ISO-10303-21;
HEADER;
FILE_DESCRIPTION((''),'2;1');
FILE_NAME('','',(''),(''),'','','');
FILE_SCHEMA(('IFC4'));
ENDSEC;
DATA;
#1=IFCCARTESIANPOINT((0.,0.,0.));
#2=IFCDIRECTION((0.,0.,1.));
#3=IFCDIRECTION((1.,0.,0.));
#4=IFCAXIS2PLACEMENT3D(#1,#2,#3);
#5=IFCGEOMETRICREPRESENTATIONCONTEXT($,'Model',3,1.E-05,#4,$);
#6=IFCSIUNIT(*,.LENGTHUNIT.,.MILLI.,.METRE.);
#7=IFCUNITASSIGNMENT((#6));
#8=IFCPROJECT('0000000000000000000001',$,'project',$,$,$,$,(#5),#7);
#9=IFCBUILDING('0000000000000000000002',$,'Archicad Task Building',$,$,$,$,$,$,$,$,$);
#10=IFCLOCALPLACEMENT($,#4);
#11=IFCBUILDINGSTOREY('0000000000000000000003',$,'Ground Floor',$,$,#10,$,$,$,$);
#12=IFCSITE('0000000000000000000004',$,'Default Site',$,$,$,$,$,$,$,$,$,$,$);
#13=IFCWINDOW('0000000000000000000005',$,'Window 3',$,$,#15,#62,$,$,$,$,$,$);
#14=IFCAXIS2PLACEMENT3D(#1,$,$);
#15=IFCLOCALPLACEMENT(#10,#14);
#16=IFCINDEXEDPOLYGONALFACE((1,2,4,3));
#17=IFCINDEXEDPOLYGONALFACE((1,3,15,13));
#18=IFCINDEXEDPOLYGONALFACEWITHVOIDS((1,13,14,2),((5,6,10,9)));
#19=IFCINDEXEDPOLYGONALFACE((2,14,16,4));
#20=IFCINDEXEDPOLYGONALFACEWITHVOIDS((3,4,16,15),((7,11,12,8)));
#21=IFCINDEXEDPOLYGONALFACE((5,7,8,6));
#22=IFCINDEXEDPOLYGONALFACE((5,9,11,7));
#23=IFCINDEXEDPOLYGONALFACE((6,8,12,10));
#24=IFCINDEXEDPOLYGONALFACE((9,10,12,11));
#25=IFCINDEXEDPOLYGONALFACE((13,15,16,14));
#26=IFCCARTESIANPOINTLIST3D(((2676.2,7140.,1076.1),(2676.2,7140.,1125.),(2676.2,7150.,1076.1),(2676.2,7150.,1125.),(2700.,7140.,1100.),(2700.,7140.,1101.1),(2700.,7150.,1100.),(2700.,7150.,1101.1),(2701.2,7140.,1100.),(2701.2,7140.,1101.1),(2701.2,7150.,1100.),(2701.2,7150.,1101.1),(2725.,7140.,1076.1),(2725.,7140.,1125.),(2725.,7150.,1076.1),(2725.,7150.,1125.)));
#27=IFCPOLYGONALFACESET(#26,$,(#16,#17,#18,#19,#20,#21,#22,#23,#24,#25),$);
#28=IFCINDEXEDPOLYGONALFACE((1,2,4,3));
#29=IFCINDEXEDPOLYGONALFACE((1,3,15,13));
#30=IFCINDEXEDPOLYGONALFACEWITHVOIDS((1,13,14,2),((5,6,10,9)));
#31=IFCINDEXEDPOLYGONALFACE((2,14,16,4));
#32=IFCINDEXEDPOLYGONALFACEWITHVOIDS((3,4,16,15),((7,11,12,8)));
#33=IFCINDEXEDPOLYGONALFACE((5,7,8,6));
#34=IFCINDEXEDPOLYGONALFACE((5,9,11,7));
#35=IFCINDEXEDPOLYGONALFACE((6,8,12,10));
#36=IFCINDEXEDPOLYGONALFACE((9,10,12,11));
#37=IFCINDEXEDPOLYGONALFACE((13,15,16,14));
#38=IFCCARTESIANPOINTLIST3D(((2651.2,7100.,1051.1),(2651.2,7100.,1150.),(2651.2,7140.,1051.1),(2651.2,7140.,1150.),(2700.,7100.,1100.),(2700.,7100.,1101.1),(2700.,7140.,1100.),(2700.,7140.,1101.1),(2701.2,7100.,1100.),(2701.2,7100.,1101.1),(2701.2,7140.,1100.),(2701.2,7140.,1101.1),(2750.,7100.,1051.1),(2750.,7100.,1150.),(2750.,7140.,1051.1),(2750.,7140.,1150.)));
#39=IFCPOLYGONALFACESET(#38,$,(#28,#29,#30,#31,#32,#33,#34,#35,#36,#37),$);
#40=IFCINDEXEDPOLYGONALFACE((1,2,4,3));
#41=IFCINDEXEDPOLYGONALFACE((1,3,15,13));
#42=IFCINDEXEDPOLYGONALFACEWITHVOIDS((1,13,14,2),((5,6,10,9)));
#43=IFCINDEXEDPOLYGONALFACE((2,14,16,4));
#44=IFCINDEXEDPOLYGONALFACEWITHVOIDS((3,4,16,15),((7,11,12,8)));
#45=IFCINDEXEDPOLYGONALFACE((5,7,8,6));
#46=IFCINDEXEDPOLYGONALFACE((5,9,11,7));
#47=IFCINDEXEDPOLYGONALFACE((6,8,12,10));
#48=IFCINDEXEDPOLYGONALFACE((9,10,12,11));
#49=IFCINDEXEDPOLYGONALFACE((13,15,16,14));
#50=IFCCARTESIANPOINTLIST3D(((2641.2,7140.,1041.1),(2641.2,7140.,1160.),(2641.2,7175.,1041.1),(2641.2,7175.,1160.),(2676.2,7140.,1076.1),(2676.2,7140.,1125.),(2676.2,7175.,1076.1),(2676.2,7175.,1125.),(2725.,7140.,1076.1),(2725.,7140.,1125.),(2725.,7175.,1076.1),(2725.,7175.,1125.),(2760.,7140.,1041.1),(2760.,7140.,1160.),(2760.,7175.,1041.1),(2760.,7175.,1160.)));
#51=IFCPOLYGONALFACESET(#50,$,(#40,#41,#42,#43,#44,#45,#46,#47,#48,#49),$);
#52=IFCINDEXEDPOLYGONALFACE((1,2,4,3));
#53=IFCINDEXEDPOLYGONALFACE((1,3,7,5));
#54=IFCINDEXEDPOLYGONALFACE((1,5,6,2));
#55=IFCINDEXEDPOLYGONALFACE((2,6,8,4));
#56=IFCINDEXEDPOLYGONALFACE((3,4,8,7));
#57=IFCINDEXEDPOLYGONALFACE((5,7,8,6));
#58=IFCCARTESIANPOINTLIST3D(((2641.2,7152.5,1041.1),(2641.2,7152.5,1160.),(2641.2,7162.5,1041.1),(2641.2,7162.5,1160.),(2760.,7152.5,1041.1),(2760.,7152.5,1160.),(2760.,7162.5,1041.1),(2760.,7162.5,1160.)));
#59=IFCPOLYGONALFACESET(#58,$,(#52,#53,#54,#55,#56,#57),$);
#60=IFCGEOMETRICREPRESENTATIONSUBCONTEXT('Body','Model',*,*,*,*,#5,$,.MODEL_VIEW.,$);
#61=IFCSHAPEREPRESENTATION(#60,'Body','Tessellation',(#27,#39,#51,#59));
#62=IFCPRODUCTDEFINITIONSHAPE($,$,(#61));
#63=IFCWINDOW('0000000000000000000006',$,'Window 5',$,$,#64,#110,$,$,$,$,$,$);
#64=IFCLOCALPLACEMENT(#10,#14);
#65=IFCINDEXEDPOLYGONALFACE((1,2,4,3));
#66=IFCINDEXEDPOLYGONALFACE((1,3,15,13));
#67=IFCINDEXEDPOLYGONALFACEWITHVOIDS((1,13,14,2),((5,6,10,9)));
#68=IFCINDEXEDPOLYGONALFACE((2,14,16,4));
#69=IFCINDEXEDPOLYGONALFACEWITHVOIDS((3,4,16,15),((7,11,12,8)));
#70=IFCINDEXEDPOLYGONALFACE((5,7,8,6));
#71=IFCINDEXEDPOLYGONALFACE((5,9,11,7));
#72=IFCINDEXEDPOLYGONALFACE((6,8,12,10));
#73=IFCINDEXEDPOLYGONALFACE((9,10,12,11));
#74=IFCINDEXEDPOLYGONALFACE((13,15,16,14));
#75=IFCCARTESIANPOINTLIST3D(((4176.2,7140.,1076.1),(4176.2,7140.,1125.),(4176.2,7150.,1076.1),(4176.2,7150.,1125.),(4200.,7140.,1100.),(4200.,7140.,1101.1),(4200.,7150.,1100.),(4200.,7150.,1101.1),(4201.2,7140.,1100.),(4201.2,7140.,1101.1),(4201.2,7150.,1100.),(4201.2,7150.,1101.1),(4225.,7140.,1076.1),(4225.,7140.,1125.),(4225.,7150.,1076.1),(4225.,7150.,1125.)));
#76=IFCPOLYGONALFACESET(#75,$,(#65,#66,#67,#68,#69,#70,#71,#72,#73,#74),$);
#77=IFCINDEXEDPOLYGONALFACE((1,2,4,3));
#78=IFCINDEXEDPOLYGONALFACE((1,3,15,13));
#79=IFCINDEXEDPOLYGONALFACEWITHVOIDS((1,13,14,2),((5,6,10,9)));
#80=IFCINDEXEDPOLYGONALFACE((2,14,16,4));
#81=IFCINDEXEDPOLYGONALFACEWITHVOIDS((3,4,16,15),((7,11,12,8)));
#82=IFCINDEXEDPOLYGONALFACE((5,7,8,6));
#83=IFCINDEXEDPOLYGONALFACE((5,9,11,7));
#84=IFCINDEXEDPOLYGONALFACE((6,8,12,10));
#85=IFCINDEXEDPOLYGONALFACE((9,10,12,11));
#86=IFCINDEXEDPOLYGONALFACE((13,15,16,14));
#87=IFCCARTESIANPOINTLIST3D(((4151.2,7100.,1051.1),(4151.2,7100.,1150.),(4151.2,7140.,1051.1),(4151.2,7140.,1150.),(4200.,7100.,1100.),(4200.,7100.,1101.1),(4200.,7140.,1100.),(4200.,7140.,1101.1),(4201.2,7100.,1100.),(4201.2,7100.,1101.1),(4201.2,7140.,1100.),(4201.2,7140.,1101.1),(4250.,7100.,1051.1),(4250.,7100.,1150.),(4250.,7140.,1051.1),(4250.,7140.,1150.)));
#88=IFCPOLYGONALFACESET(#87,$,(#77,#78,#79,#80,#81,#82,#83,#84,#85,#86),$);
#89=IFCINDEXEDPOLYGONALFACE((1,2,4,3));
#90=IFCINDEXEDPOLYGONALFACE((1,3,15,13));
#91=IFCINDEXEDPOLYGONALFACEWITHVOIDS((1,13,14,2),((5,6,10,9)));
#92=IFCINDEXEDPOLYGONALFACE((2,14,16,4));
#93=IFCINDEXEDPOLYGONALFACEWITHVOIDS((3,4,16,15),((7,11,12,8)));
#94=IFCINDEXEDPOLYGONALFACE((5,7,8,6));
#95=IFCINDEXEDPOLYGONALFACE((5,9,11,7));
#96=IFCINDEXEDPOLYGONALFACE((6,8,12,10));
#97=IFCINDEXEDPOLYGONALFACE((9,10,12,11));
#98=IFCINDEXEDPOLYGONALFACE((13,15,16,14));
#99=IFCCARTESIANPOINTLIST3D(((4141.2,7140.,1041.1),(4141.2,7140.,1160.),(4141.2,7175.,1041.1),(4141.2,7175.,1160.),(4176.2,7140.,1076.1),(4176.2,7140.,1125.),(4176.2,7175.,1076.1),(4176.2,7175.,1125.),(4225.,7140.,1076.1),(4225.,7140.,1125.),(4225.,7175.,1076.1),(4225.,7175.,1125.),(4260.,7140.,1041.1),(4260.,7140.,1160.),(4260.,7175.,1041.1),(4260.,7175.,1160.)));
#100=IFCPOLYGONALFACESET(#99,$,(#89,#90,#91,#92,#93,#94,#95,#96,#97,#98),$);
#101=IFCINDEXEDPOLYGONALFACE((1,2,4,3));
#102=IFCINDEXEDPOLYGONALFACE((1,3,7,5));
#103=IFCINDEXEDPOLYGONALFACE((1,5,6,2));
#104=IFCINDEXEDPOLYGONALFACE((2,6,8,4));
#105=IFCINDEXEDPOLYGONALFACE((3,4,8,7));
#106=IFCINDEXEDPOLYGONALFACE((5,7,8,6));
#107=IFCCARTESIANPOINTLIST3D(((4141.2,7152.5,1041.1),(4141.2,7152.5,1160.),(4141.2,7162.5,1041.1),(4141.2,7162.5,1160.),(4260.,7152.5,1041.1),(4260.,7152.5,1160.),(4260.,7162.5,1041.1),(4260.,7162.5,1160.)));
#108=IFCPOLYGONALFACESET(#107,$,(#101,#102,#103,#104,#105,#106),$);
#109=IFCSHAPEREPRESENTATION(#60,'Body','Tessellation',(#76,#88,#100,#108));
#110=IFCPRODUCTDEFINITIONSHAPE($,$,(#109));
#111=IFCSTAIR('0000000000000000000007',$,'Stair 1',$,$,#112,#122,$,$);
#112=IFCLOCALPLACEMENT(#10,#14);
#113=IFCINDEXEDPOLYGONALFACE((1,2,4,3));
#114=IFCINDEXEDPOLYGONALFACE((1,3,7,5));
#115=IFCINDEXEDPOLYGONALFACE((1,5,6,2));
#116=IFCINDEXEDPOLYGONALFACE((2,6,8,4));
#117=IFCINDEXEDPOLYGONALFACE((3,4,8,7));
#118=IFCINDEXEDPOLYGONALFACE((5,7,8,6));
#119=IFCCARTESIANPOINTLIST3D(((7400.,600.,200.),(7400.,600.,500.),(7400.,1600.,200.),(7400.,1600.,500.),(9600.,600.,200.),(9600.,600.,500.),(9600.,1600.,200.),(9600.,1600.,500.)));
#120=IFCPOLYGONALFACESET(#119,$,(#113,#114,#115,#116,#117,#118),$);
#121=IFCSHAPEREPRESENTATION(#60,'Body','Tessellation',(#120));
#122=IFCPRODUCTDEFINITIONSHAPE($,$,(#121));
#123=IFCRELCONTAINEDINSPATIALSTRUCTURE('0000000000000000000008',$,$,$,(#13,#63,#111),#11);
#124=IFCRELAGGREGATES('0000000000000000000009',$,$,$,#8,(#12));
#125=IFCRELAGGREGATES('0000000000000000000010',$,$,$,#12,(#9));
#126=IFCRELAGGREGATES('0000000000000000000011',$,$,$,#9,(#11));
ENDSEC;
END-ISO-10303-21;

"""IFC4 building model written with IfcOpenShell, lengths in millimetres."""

from ifc_helpers import new_model, si_unit, frame, origin_with_axes, place, context, subcontext, project, spatial, line, indexed_curve, outline, extrude, element, save


model = new_model("IFC4")

# Units and contexts
model_context = context("Model", 3, precision=1e-05, world=origin_with_axes())
body_context = subcontext(model_context, "Body", "Model", "MODEL_VIEW")
ifc_project = project(units=[si_unit("LENGTHUNIT", "METRE", prefix="MILLI")], contexts=[model_context])

# Site, building, storey
site = spatial("IfcSite", under=ifc_project, Name="Default Site")
building = spatial("IfcBuilding", under=site, Name="Archicad Task Building")
storey_placement = place(None, origin_with_axes())
storey = spatial("IfcBuildingStorey", under=building, at=storey_placement, Name="Ground Floor")

# Windows
for number, where, z_axis, x_axis, name in (
    (1, (2700.0, 7050.0, 1100.0), (0.0, 0.0, 1.0), (1.0, 0.0, 0.0), "Window 3"),
    (2, (4200.0, 7050.0, 1100.0), (0.0, 0.0, 1.0), (1.0, 0.0, 0.0), "Window 5"),
):
    element("IfcWindow", number, at=place(storey_placement, frame(where, z_axis=z_axis, x_axis=x_axis)), inside=storey, Name=name, context=body_context, shape_type="SweptSolid", body=[
        extrude(outline(indexed_curve([(0.0, 0.0), (1.2, 0.0), (1.2, 1.1), (0.0, 1.1)], segments=[line(1, 2, 3, 4, 1)]), holes=[indexed_curve([(25.0, 25.0), (-23.8, 25.0), (-23.8, -23.9), (25.0, -23.9)], segments=[line(1, 2, 3, 4, 1)])]), frame((0.0, 90.0, 0.0), z_axis=(0.0, -1.0, 0.0), x_axis=(1.0, 0.0, 0.0)), (0.0, 0.0, -1.0), 10.0),
        extrude(outline(indexed_curve([(0.0, 0.0), (1.2, 0.0), (1.2, 1.1), (0.0, 1.1)], segments=[line(1, 2, 3, 4, 1)]), holes=[indexed_curve([(50.0, 50.0), (-48.8, 50.0), (-48.8, -48.9), (50.0, -48.9)], segments=[line(1, 2, 3, 4, 1)])]), frame((0.0, 50.0, 0.0), z_axis=(0.0, -1.0, 0.0), x_axis=(1.0, 0.0, 0.0)), (0.0, 0.0, -1.0), 40.0),
        extrude(outline(indexed_curve([(0.0, 0.0), (-48.8, 0.0), (-48.8, -48.9), (0.0, -48.9)], segments=[line(1, 2, 3, 4, 1)]), holes=[indexed_curve([(35.0, 35.0), (-83.8, 35.0), (-83.8, -83.9), (35.0, -83.9)], segments=[line(1, 2, 3, 4, 1)])]), frame((25.0, 90.0, 25.0), z_axis=(0.0, -1.0, 0.0), x_axis=(1.0, 0.0, 0.0)), (0.0, 0.0, -1.0), 35.0),
        extrude(outline(indexed_curve([(35.0, 35.0), (-83.8, 35.0), (-83.8, -83.9), (35.0, -83.9)], segments=[line(1, 2, 3, 4, 1)])), frame((25.0, 102.5, 25.0), z_axis=(0.0, -1.0, 0.0), x_axis=(1.0, 0.0, 0.0)), (0.0, 0.0, -1.0), 10.0),
    ])

# Stair
stair_placement = place(storey_placement, frame((7400.0, 600.0, 200.0), z_axis=(0.0, 0.0, 1.0), x_axis=(1.0, 0.0, 0.0)))
element("IfcStair", 3, at=stair_placement, inside=storey, Name="Stair 1", context=body_context, shape_type="SweptSolid", body=[
    extrude(outline(indexed_curve([(0.0, 0.0), (2200.0, 0.0), (2200.0, 1000.0), (0.0, 1000.0), (0.0, 0.0)])), None, (0.0, 0.0, 1.0), 300.0),
])

save(model, "model.ifc")
